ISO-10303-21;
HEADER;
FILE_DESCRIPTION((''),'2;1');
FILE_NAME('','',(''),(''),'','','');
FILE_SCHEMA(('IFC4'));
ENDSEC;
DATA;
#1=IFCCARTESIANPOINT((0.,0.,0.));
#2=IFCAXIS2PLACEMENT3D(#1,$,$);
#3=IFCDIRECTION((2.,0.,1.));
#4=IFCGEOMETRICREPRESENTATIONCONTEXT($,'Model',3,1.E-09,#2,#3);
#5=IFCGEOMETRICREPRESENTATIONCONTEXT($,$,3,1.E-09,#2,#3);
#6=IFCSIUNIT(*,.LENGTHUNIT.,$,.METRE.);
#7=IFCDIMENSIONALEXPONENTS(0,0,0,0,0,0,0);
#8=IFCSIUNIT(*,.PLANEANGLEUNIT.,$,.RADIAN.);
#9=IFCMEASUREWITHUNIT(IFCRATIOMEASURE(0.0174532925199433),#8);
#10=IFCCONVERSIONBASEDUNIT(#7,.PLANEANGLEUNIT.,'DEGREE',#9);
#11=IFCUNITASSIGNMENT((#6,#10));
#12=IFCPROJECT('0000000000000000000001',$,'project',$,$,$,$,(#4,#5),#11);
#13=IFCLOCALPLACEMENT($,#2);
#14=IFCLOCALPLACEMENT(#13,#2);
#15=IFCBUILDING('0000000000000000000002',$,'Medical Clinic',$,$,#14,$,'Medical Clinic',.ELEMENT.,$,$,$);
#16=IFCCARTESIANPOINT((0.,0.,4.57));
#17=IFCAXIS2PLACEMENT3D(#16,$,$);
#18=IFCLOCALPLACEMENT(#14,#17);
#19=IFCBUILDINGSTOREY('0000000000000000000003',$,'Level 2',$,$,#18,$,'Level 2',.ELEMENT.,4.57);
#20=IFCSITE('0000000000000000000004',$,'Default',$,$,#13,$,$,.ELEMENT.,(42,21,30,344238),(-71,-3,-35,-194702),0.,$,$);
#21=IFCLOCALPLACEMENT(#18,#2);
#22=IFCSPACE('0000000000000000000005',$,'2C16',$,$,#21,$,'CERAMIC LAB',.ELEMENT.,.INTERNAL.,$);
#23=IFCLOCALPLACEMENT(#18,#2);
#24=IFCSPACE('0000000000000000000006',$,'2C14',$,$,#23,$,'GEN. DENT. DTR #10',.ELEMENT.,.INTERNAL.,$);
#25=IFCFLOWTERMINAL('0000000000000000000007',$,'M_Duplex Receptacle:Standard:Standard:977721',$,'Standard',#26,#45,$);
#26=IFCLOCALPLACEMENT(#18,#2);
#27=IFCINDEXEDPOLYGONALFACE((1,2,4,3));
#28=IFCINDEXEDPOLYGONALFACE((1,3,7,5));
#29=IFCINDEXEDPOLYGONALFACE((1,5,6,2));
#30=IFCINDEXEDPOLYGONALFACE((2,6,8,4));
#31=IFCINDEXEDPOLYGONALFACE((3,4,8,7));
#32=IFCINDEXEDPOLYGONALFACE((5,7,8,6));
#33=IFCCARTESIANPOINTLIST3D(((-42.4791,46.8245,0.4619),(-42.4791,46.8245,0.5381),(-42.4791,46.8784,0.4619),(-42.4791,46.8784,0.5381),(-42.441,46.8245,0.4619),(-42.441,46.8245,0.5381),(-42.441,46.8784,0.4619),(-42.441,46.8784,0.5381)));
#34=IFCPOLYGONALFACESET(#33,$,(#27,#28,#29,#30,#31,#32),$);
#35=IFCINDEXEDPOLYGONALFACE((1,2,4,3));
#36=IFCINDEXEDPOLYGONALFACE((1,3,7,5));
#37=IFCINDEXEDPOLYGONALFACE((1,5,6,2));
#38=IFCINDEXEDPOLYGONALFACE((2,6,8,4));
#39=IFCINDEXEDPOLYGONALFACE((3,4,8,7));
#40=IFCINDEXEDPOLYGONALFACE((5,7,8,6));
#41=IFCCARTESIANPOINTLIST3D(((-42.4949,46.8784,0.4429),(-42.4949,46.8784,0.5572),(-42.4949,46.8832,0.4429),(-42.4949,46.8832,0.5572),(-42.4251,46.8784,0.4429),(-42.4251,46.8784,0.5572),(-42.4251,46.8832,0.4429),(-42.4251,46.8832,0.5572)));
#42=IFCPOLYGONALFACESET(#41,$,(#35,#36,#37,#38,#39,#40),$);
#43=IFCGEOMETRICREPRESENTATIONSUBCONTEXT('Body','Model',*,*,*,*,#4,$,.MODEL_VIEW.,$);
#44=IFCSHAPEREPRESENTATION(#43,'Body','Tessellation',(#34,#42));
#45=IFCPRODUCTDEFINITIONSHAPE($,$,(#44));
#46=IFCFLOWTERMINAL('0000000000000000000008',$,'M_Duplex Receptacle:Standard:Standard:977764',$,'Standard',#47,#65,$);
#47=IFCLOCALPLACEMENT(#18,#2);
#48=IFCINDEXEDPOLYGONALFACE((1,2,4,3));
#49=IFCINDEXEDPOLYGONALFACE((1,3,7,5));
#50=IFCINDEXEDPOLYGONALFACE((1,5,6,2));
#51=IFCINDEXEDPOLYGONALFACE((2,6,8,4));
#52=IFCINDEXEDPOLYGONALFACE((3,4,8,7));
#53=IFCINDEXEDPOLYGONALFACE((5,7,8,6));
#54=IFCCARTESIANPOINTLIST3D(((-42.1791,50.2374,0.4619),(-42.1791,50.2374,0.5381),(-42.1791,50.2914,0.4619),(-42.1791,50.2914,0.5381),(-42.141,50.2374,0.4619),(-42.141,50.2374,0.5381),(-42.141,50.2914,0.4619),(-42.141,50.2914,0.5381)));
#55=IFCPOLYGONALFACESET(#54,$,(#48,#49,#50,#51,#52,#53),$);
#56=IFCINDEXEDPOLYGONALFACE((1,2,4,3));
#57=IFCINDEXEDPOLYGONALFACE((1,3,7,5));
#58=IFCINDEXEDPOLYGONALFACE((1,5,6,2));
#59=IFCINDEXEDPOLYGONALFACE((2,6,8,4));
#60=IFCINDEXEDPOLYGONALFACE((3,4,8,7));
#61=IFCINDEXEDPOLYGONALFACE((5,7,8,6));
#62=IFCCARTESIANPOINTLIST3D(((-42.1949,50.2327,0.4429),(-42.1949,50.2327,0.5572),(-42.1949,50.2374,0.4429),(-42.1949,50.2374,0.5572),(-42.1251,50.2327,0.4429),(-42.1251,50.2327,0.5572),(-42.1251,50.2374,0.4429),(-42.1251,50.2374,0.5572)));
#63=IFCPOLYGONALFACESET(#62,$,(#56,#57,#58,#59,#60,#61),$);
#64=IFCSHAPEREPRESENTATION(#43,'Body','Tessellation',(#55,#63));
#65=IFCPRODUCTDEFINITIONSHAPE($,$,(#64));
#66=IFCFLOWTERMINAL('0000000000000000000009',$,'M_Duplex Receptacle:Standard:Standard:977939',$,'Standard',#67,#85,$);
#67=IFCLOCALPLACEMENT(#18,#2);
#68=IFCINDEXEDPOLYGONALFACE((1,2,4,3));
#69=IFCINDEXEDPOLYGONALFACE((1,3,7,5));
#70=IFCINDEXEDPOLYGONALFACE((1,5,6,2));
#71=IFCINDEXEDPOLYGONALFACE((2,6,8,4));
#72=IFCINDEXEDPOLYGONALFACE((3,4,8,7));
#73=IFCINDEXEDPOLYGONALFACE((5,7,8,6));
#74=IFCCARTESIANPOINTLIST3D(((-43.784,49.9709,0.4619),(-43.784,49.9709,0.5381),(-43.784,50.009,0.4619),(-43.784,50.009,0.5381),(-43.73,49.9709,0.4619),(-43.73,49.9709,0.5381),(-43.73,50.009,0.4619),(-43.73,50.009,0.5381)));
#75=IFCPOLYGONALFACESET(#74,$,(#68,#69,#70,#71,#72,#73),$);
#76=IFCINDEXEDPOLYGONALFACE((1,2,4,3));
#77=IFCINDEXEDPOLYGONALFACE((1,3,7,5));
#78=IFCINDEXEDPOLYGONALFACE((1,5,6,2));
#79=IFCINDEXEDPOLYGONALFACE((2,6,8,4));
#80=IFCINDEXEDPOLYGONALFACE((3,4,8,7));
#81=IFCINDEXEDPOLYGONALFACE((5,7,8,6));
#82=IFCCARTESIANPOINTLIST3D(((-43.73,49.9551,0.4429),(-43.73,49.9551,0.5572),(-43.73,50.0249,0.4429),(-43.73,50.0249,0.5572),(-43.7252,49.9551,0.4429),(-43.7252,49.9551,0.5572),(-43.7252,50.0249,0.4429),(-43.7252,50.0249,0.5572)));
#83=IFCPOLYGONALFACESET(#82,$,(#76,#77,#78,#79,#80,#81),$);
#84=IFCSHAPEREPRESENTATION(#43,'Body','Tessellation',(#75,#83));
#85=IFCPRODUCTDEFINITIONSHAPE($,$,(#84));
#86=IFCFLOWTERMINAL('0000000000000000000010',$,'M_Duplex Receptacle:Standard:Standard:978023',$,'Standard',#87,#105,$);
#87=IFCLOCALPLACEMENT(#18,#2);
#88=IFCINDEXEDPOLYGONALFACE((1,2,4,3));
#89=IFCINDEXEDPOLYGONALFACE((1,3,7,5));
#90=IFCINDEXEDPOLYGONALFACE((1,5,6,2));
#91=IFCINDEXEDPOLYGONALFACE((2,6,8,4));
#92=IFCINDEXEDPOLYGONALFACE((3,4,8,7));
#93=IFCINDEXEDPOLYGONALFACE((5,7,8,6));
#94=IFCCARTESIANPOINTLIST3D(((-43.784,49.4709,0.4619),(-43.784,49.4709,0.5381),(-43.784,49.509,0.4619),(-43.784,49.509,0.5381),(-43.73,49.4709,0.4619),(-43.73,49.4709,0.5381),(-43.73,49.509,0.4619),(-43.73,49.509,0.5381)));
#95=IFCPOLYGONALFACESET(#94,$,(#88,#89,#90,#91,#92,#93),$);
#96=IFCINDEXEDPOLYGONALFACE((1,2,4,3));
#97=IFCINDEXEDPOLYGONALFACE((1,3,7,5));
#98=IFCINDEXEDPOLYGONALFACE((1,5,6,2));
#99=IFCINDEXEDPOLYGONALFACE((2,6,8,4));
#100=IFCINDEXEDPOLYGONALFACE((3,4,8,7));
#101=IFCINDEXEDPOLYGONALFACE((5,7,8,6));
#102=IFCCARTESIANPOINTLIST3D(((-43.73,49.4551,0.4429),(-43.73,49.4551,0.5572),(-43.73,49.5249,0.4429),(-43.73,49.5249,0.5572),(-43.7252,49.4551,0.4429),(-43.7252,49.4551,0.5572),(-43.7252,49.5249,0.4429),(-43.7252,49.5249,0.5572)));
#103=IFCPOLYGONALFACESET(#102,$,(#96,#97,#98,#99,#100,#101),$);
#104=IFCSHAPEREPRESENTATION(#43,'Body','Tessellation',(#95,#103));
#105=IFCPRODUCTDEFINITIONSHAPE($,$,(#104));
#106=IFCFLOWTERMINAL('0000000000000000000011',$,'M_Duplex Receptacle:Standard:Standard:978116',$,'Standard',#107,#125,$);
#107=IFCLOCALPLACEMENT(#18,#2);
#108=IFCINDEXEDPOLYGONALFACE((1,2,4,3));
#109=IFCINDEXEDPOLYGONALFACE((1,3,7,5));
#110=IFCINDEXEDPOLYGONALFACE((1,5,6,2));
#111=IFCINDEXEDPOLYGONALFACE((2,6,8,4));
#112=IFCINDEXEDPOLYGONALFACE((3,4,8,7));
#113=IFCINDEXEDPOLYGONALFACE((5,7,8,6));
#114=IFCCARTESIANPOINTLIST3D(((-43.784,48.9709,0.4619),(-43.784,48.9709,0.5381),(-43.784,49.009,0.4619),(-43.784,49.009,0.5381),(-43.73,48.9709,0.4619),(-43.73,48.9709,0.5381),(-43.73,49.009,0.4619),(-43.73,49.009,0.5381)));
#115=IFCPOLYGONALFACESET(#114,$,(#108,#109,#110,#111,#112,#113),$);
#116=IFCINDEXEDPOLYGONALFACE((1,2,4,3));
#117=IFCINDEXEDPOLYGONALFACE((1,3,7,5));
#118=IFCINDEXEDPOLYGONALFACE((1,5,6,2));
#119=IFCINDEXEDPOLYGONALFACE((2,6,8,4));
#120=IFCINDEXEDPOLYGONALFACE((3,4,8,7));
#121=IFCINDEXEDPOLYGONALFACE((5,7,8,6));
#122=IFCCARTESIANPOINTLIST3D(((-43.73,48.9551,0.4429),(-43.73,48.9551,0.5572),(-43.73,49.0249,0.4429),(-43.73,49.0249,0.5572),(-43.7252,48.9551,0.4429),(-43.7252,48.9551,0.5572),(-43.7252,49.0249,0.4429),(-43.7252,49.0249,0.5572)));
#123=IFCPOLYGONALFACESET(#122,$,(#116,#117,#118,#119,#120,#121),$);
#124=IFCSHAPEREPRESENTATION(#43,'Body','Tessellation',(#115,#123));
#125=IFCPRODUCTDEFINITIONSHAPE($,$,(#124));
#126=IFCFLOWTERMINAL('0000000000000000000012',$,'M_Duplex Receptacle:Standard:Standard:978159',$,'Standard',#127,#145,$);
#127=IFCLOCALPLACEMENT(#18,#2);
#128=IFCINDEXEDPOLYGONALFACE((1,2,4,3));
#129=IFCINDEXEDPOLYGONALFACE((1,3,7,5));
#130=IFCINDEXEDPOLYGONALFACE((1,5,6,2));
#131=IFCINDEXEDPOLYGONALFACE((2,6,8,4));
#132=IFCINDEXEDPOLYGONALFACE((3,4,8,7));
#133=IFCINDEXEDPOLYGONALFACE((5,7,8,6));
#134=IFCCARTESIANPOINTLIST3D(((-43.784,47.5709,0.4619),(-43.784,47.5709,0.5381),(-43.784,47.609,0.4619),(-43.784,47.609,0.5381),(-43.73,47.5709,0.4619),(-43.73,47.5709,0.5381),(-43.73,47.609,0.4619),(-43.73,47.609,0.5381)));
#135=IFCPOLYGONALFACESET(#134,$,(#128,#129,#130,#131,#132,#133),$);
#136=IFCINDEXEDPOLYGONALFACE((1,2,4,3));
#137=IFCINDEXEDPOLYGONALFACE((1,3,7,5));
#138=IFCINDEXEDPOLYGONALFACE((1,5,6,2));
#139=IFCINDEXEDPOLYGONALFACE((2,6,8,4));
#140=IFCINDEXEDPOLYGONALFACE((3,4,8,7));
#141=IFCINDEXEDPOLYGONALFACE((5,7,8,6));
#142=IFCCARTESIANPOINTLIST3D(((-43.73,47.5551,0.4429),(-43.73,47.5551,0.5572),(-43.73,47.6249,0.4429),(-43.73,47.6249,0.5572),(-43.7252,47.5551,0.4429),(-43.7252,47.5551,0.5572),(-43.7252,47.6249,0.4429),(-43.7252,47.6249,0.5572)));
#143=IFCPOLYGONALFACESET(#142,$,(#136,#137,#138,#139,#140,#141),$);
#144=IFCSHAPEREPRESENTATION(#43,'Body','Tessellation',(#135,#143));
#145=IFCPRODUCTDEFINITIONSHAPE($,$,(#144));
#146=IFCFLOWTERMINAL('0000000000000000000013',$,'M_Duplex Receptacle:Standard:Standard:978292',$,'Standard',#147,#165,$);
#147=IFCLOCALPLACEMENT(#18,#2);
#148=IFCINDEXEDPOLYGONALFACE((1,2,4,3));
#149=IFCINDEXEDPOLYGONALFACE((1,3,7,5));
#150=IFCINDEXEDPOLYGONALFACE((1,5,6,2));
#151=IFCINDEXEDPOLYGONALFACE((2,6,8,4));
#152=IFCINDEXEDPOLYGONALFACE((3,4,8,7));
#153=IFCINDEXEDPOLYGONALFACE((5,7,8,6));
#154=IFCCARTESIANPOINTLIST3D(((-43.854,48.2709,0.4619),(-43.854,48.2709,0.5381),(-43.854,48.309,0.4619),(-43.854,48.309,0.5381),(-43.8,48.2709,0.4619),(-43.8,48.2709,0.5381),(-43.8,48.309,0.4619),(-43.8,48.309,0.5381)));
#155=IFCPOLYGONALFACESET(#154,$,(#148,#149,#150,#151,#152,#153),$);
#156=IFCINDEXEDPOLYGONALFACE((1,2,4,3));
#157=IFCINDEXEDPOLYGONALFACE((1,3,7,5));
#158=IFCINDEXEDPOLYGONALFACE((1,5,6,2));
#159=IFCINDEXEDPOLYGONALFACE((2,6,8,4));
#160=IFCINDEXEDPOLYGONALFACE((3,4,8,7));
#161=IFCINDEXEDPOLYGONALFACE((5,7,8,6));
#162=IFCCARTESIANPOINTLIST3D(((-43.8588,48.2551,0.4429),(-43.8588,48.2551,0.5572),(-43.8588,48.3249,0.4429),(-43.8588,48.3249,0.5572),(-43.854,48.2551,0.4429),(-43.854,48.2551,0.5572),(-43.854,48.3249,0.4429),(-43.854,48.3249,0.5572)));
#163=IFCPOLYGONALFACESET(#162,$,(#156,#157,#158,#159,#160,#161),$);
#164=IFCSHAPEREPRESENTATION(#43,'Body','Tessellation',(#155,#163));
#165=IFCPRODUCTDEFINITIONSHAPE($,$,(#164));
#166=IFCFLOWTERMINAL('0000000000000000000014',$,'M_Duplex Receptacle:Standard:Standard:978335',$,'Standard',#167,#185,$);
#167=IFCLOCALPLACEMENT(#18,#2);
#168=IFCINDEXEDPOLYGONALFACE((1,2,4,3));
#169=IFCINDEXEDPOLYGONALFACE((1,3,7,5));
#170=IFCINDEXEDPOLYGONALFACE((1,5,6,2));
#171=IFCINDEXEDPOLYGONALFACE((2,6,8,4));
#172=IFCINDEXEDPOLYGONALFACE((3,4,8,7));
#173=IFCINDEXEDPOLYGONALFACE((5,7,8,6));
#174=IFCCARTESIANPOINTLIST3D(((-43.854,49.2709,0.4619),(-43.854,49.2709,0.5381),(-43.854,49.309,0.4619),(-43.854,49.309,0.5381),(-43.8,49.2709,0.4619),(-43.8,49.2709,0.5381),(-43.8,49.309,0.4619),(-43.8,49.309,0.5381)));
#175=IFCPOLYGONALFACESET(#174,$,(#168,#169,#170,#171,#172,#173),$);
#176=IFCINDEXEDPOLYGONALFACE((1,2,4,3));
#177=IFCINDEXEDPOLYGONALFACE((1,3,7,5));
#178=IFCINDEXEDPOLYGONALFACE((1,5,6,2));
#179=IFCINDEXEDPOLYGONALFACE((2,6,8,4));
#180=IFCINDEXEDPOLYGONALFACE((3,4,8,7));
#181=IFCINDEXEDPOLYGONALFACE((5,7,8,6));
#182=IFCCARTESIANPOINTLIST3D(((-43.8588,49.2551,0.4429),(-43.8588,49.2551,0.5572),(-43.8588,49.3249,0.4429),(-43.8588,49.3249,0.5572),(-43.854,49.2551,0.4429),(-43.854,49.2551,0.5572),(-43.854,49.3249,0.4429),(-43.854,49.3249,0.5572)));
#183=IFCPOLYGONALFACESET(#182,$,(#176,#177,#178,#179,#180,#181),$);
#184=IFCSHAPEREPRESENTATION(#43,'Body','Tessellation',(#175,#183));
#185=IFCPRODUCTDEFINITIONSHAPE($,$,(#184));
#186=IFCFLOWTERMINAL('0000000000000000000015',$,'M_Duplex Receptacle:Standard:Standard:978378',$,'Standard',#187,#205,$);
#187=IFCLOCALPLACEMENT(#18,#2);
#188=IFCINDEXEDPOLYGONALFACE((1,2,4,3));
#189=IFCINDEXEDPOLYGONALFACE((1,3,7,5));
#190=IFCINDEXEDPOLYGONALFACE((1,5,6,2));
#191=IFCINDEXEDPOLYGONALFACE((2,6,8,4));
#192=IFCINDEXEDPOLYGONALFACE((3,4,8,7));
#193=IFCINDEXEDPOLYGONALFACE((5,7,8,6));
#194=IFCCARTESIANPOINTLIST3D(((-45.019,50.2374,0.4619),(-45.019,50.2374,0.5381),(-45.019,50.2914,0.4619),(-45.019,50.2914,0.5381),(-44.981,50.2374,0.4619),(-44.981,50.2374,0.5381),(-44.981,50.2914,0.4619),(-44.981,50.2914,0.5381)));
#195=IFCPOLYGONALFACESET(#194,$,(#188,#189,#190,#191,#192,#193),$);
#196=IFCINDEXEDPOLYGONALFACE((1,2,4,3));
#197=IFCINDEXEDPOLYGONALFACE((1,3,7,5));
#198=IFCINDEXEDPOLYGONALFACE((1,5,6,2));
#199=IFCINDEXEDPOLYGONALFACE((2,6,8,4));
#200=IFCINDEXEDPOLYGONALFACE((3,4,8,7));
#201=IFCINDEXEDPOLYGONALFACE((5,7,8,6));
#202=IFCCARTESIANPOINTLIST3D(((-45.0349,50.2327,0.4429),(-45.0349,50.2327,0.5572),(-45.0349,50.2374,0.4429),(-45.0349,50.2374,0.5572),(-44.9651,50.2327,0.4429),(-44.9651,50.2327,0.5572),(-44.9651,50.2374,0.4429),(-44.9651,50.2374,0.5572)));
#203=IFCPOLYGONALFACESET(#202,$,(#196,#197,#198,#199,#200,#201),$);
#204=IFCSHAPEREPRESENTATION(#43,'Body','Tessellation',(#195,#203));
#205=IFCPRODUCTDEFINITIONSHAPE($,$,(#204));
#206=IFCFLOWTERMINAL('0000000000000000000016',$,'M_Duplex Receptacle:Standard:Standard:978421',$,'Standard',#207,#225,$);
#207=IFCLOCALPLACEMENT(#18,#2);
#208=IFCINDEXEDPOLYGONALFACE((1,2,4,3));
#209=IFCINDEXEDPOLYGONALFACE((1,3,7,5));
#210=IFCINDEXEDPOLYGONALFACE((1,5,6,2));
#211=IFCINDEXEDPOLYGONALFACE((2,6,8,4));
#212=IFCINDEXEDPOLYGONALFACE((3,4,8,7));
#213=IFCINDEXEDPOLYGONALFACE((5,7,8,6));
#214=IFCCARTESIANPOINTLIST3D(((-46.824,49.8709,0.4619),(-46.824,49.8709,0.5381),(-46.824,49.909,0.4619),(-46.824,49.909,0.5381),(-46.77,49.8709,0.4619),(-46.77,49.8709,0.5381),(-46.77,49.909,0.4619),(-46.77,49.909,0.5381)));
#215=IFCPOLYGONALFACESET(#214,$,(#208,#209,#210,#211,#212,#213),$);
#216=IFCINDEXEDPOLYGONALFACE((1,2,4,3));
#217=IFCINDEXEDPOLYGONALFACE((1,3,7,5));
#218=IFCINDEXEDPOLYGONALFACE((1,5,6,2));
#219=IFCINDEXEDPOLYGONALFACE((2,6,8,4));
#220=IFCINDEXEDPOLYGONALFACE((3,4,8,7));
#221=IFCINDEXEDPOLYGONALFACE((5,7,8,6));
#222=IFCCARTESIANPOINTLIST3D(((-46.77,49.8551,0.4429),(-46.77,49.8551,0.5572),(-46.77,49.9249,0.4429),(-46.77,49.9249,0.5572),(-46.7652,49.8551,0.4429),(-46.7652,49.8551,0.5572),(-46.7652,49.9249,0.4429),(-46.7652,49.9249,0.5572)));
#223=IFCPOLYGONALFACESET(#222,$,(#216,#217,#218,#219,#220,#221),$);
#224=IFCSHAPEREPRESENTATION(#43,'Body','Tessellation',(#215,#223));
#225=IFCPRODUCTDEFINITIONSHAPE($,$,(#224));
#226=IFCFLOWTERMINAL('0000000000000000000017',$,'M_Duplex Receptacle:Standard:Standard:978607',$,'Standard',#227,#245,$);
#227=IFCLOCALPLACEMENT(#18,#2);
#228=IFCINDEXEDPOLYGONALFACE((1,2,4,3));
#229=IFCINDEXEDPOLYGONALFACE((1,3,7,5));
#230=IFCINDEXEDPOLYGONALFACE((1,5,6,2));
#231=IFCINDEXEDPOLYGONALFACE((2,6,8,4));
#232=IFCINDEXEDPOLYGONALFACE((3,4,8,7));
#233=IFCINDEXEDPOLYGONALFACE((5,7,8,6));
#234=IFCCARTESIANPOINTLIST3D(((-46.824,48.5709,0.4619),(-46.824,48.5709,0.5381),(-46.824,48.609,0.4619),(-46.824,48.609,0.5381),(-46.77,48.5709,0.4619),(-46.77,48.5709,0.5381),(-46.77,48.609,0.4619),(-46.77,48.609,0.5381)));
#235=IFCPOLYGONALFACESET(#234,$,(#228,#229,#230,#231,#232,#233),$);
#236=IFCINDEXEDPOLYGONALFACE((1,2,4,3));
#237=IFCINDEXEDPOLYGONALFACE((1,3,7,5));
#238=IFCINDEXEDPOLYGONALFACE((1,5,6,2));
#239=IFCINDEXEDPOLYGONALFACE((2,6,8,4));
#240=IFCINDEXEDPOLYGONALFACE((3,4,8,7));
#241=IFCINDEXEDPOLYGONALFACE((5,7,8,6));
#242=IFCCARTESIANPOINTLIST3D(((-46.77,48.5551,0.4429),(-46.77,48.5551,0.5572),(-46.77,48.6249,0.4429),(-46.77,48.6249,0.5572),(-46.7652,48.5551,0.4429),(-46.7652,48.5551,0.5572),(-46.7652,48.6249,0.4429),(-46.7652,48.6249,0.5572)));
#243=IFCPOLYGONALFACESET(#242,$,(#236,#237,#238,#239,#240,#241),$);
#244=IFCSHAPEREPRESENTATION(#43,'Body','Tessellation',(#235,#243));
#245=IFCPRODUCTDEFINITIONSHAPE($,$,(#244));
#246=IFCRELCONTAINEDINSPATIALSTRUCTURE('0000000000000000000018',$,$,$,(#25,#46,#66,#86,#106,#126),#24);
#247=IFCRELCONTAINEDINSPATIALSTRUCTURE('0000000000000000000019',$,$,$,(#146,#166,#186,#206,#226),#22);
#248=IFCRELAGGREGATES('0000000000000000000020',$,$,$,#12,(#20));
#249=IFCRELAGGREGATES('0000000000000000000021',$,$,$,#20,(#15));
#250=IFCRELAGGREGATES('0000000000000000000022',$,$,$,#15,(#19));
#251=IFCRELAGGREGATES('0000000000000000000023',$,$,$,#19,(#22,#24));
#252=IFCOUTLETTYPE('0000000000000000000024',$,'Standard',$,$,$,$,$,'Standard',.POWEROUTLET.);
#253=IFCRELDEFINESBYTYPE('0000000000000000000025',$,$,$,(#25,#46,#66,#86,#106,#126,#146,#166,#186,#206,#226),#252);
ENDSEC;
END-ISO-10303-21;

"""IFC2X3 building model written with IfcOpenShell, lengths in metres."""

from ifc_helpers import new_model, entity, si_unit, converted_unit, direction, frame, frame_2d, origin, origin_2d_with_axis, place, context, subcontext, project, spatial, rectangle, extrude, source, transform, mapped, type_object, type_shapes, element, save


model = new_model("IFC2X3")

# Units and contexts
model_context = context("Model", 3, precision=1e-09, world=origin(), true_north=direction((2.0, 0.0, 1.0)))
context_of_model = context(None, 3, precision=1e-09, world=origin(), true_north=direction((2.0, 0.0, 1.0)))
body_context = subcontext(model_context, "Body", "Model", "MODEL_VIEW")
ifc_project = project(units=[si_unit("LENGTHUNIT", "METRE"), converted_unit("PLANEANGLEUNIT", "DEGREE", entity("IfcRatioMeasure", 0.0174532925199433), si_unit("PLANEANGLEUNIT", "RADIAN"), dimensions=[0, 0, 0, 0, 0, 0, 0])], contexts=[model_context, context_of_model])

# Site, building, storey
site_placement = place(None, origin())
site = spatial("IfcSite", under=ifc_project, at=site_placement, Name="Default", CompositionType="ELEMENT", RefLatitude=(42, 21, 30, 344238), RefLongitude=(-71, -3, -35, -194702), RefElevation=0.0)
building_placement = place(site_placement, origin())
building = spatial("IfcBuilding", under=site, at=building_placement, Name="Medical Clinic", LongName="Medical Clinic", CompositionType="ELEMENT")
storey_placement = place(building_placement, frame((0.0, 0.0, 4.57)))
storey = spatial("IfcBuildingStorey", under=building, at=storey_placement, Name="Level 2", LongName="Level 2", CompositionType="ELEMENT", Elevation=4.57)

# Shared definitions
space_1_placement = place(storey_placement, origin())
space_1 = spatial("IfcSpace", under=storey, at=space_1_placement, Name="2C16", LongName="CERAMIC LAB", CompositionType="ELEMENT", InteriorOrExteriorSpace="INTERNAL")

# Shared definitions
space_2_placement = place(storey_placement, origin())
space_2 = spatial("IfcSpace", under=storey, at=space_2_placement, Name="2C14", LongName="GEN. DENT. DTR #10", CompositionType="ELEMENT", InteriorOrExteriorSpace="INTERNAL")

# Flow terminals
outlet_type = type_object("IfcOutletType", Name="Standard", ElementType="Standard", PredefinedType="POWEROUTLET")
shared_shape_1 = source(origin(), body_context, "Body", "SweptSolid", [
    extrude(rectangle(XDim=0.0381, YDim=0.0762, at=origin_2d_with_axis()), frame((0.0, 0.0, -0.054), z_axis=(0.0, 0.0, 1.0), x_axis=(-1.0, 0.0, 0.0)), (0.0, 0.0, 1.0), 0.054),
    extrude(rectangle(XDim=0.0698, YDim=0.1143, at=frame_2d((0.0, 0.0), x_axis=(1.0, 0.0))), frame((0.0, 0.0, 0.0), z_axis=(0.0, 0.0, 1.0), x_axis=(-1.0, 0.0, 0.0)), (0.0, 0.0, 1.0), 0.0048),
])
type_shapes(outlet_type, [shared_shape_1])
for number, where, z_axis, x_axis, name in (
    (1, (-42.46, 46.8784, 0.5), (0.0, 1.0, 0.0), (-1.0, 0.0, 0.0), "M_Duplex Receptacle:Standard:Standard:977721"),
    (2, (-42.16, 50.2374, 0.5), (0.0, -1.0, 0.0), (1.0, 0.0, 0.0), "M_Duplex Receptacle:Standard:Standard:977764"),
    (3, (-43.73, 49.99, 0.5), (1.0, 0.0, 0.0), (0.0, 1.0, 0.0), "M_Duplex Receptacle:Standard:Standard:977939"),
    (4, (-43.73, 49.49, 0.5), (1.0, 0.0, 0.0), (0.0, 1.0, 0.0), "M_Duplex Receptacle:Standard:Standard:978023"),
    (5, (-43.73, 48.99, 0.5), (1.0, 0.0, 0.0), (0.0, 1.0, 0.0), "M_Duplex Receptacle:Standard:Standard:978116"),
    (6, (-43.73, 47.59, 0.5), (1.0, 0.0, 0.0), (0.0, 1.0, 0.0), "M_Duplex Receptacle:Standard:Standard:978159"),
):
    element("IfcFlowTerminal", number, at=place(space_2_placement, frame(where, z_axis=z_axis, x_axis=x_axis)), inside=space_2, type_object=outlet_type, Name=name, ObjectType="Standard", context=body_context, shape_type="MappedRepresentation", body=[
        mapped(shared_shape_1, transform((0.0, 0.0, 0.0), scale=1.0)),
    ])
for number, where, z_axis, x_axis, name in (
    (7, (-43.854, 48.29, 0.5), (-1.0, 0.0, 0.0), (0.0, -1.0, 0.0), "M_Duplex Receptacle:Standard:Standard:978292"),
    (8, (-43.854, 49.29, 0.5), (-1.0, 0.0, 0.0), (0.0, -1.0, 0.0), "M_Duplex Receptacle:Standard:Standard:978335"),
    (9, (-45.0, 50.2374, 0.5), (0.0, -1.0, 0.0), (1.0, 0.0, 0.0), "M_Duplex Receptacle:Standard:Standard:978378"),
    (10, (-46.77, 49.89, 0.5), (1.0, 0.0, 0.0), (0.0, 1.0, 0.0), "M_Duplex Receptacle:Standard:Standard:978421"),
    (11, (-46.77, 48.59, 0.5), (1.0, 0.0, 0.0), (0.0, 1.0, 0.0), "M_Duplex Receptacle:Standard:Standard:978607"),
):
    element("IfcFlowTerminal", number, at=place(space_1_placement, frame(where, z_axis=z_axis, x_axis=x_axis)), inside=space_1, type_object=outlet_type, Name=name, ObjectType="Standard", context=body_context, shape_type="MappedRepresentation", body=[
        mapped(shared_shape_1, transform((0.0, 0.0, 0.0), scale=1.0)),
    ])

save(model, "model.ifc")
